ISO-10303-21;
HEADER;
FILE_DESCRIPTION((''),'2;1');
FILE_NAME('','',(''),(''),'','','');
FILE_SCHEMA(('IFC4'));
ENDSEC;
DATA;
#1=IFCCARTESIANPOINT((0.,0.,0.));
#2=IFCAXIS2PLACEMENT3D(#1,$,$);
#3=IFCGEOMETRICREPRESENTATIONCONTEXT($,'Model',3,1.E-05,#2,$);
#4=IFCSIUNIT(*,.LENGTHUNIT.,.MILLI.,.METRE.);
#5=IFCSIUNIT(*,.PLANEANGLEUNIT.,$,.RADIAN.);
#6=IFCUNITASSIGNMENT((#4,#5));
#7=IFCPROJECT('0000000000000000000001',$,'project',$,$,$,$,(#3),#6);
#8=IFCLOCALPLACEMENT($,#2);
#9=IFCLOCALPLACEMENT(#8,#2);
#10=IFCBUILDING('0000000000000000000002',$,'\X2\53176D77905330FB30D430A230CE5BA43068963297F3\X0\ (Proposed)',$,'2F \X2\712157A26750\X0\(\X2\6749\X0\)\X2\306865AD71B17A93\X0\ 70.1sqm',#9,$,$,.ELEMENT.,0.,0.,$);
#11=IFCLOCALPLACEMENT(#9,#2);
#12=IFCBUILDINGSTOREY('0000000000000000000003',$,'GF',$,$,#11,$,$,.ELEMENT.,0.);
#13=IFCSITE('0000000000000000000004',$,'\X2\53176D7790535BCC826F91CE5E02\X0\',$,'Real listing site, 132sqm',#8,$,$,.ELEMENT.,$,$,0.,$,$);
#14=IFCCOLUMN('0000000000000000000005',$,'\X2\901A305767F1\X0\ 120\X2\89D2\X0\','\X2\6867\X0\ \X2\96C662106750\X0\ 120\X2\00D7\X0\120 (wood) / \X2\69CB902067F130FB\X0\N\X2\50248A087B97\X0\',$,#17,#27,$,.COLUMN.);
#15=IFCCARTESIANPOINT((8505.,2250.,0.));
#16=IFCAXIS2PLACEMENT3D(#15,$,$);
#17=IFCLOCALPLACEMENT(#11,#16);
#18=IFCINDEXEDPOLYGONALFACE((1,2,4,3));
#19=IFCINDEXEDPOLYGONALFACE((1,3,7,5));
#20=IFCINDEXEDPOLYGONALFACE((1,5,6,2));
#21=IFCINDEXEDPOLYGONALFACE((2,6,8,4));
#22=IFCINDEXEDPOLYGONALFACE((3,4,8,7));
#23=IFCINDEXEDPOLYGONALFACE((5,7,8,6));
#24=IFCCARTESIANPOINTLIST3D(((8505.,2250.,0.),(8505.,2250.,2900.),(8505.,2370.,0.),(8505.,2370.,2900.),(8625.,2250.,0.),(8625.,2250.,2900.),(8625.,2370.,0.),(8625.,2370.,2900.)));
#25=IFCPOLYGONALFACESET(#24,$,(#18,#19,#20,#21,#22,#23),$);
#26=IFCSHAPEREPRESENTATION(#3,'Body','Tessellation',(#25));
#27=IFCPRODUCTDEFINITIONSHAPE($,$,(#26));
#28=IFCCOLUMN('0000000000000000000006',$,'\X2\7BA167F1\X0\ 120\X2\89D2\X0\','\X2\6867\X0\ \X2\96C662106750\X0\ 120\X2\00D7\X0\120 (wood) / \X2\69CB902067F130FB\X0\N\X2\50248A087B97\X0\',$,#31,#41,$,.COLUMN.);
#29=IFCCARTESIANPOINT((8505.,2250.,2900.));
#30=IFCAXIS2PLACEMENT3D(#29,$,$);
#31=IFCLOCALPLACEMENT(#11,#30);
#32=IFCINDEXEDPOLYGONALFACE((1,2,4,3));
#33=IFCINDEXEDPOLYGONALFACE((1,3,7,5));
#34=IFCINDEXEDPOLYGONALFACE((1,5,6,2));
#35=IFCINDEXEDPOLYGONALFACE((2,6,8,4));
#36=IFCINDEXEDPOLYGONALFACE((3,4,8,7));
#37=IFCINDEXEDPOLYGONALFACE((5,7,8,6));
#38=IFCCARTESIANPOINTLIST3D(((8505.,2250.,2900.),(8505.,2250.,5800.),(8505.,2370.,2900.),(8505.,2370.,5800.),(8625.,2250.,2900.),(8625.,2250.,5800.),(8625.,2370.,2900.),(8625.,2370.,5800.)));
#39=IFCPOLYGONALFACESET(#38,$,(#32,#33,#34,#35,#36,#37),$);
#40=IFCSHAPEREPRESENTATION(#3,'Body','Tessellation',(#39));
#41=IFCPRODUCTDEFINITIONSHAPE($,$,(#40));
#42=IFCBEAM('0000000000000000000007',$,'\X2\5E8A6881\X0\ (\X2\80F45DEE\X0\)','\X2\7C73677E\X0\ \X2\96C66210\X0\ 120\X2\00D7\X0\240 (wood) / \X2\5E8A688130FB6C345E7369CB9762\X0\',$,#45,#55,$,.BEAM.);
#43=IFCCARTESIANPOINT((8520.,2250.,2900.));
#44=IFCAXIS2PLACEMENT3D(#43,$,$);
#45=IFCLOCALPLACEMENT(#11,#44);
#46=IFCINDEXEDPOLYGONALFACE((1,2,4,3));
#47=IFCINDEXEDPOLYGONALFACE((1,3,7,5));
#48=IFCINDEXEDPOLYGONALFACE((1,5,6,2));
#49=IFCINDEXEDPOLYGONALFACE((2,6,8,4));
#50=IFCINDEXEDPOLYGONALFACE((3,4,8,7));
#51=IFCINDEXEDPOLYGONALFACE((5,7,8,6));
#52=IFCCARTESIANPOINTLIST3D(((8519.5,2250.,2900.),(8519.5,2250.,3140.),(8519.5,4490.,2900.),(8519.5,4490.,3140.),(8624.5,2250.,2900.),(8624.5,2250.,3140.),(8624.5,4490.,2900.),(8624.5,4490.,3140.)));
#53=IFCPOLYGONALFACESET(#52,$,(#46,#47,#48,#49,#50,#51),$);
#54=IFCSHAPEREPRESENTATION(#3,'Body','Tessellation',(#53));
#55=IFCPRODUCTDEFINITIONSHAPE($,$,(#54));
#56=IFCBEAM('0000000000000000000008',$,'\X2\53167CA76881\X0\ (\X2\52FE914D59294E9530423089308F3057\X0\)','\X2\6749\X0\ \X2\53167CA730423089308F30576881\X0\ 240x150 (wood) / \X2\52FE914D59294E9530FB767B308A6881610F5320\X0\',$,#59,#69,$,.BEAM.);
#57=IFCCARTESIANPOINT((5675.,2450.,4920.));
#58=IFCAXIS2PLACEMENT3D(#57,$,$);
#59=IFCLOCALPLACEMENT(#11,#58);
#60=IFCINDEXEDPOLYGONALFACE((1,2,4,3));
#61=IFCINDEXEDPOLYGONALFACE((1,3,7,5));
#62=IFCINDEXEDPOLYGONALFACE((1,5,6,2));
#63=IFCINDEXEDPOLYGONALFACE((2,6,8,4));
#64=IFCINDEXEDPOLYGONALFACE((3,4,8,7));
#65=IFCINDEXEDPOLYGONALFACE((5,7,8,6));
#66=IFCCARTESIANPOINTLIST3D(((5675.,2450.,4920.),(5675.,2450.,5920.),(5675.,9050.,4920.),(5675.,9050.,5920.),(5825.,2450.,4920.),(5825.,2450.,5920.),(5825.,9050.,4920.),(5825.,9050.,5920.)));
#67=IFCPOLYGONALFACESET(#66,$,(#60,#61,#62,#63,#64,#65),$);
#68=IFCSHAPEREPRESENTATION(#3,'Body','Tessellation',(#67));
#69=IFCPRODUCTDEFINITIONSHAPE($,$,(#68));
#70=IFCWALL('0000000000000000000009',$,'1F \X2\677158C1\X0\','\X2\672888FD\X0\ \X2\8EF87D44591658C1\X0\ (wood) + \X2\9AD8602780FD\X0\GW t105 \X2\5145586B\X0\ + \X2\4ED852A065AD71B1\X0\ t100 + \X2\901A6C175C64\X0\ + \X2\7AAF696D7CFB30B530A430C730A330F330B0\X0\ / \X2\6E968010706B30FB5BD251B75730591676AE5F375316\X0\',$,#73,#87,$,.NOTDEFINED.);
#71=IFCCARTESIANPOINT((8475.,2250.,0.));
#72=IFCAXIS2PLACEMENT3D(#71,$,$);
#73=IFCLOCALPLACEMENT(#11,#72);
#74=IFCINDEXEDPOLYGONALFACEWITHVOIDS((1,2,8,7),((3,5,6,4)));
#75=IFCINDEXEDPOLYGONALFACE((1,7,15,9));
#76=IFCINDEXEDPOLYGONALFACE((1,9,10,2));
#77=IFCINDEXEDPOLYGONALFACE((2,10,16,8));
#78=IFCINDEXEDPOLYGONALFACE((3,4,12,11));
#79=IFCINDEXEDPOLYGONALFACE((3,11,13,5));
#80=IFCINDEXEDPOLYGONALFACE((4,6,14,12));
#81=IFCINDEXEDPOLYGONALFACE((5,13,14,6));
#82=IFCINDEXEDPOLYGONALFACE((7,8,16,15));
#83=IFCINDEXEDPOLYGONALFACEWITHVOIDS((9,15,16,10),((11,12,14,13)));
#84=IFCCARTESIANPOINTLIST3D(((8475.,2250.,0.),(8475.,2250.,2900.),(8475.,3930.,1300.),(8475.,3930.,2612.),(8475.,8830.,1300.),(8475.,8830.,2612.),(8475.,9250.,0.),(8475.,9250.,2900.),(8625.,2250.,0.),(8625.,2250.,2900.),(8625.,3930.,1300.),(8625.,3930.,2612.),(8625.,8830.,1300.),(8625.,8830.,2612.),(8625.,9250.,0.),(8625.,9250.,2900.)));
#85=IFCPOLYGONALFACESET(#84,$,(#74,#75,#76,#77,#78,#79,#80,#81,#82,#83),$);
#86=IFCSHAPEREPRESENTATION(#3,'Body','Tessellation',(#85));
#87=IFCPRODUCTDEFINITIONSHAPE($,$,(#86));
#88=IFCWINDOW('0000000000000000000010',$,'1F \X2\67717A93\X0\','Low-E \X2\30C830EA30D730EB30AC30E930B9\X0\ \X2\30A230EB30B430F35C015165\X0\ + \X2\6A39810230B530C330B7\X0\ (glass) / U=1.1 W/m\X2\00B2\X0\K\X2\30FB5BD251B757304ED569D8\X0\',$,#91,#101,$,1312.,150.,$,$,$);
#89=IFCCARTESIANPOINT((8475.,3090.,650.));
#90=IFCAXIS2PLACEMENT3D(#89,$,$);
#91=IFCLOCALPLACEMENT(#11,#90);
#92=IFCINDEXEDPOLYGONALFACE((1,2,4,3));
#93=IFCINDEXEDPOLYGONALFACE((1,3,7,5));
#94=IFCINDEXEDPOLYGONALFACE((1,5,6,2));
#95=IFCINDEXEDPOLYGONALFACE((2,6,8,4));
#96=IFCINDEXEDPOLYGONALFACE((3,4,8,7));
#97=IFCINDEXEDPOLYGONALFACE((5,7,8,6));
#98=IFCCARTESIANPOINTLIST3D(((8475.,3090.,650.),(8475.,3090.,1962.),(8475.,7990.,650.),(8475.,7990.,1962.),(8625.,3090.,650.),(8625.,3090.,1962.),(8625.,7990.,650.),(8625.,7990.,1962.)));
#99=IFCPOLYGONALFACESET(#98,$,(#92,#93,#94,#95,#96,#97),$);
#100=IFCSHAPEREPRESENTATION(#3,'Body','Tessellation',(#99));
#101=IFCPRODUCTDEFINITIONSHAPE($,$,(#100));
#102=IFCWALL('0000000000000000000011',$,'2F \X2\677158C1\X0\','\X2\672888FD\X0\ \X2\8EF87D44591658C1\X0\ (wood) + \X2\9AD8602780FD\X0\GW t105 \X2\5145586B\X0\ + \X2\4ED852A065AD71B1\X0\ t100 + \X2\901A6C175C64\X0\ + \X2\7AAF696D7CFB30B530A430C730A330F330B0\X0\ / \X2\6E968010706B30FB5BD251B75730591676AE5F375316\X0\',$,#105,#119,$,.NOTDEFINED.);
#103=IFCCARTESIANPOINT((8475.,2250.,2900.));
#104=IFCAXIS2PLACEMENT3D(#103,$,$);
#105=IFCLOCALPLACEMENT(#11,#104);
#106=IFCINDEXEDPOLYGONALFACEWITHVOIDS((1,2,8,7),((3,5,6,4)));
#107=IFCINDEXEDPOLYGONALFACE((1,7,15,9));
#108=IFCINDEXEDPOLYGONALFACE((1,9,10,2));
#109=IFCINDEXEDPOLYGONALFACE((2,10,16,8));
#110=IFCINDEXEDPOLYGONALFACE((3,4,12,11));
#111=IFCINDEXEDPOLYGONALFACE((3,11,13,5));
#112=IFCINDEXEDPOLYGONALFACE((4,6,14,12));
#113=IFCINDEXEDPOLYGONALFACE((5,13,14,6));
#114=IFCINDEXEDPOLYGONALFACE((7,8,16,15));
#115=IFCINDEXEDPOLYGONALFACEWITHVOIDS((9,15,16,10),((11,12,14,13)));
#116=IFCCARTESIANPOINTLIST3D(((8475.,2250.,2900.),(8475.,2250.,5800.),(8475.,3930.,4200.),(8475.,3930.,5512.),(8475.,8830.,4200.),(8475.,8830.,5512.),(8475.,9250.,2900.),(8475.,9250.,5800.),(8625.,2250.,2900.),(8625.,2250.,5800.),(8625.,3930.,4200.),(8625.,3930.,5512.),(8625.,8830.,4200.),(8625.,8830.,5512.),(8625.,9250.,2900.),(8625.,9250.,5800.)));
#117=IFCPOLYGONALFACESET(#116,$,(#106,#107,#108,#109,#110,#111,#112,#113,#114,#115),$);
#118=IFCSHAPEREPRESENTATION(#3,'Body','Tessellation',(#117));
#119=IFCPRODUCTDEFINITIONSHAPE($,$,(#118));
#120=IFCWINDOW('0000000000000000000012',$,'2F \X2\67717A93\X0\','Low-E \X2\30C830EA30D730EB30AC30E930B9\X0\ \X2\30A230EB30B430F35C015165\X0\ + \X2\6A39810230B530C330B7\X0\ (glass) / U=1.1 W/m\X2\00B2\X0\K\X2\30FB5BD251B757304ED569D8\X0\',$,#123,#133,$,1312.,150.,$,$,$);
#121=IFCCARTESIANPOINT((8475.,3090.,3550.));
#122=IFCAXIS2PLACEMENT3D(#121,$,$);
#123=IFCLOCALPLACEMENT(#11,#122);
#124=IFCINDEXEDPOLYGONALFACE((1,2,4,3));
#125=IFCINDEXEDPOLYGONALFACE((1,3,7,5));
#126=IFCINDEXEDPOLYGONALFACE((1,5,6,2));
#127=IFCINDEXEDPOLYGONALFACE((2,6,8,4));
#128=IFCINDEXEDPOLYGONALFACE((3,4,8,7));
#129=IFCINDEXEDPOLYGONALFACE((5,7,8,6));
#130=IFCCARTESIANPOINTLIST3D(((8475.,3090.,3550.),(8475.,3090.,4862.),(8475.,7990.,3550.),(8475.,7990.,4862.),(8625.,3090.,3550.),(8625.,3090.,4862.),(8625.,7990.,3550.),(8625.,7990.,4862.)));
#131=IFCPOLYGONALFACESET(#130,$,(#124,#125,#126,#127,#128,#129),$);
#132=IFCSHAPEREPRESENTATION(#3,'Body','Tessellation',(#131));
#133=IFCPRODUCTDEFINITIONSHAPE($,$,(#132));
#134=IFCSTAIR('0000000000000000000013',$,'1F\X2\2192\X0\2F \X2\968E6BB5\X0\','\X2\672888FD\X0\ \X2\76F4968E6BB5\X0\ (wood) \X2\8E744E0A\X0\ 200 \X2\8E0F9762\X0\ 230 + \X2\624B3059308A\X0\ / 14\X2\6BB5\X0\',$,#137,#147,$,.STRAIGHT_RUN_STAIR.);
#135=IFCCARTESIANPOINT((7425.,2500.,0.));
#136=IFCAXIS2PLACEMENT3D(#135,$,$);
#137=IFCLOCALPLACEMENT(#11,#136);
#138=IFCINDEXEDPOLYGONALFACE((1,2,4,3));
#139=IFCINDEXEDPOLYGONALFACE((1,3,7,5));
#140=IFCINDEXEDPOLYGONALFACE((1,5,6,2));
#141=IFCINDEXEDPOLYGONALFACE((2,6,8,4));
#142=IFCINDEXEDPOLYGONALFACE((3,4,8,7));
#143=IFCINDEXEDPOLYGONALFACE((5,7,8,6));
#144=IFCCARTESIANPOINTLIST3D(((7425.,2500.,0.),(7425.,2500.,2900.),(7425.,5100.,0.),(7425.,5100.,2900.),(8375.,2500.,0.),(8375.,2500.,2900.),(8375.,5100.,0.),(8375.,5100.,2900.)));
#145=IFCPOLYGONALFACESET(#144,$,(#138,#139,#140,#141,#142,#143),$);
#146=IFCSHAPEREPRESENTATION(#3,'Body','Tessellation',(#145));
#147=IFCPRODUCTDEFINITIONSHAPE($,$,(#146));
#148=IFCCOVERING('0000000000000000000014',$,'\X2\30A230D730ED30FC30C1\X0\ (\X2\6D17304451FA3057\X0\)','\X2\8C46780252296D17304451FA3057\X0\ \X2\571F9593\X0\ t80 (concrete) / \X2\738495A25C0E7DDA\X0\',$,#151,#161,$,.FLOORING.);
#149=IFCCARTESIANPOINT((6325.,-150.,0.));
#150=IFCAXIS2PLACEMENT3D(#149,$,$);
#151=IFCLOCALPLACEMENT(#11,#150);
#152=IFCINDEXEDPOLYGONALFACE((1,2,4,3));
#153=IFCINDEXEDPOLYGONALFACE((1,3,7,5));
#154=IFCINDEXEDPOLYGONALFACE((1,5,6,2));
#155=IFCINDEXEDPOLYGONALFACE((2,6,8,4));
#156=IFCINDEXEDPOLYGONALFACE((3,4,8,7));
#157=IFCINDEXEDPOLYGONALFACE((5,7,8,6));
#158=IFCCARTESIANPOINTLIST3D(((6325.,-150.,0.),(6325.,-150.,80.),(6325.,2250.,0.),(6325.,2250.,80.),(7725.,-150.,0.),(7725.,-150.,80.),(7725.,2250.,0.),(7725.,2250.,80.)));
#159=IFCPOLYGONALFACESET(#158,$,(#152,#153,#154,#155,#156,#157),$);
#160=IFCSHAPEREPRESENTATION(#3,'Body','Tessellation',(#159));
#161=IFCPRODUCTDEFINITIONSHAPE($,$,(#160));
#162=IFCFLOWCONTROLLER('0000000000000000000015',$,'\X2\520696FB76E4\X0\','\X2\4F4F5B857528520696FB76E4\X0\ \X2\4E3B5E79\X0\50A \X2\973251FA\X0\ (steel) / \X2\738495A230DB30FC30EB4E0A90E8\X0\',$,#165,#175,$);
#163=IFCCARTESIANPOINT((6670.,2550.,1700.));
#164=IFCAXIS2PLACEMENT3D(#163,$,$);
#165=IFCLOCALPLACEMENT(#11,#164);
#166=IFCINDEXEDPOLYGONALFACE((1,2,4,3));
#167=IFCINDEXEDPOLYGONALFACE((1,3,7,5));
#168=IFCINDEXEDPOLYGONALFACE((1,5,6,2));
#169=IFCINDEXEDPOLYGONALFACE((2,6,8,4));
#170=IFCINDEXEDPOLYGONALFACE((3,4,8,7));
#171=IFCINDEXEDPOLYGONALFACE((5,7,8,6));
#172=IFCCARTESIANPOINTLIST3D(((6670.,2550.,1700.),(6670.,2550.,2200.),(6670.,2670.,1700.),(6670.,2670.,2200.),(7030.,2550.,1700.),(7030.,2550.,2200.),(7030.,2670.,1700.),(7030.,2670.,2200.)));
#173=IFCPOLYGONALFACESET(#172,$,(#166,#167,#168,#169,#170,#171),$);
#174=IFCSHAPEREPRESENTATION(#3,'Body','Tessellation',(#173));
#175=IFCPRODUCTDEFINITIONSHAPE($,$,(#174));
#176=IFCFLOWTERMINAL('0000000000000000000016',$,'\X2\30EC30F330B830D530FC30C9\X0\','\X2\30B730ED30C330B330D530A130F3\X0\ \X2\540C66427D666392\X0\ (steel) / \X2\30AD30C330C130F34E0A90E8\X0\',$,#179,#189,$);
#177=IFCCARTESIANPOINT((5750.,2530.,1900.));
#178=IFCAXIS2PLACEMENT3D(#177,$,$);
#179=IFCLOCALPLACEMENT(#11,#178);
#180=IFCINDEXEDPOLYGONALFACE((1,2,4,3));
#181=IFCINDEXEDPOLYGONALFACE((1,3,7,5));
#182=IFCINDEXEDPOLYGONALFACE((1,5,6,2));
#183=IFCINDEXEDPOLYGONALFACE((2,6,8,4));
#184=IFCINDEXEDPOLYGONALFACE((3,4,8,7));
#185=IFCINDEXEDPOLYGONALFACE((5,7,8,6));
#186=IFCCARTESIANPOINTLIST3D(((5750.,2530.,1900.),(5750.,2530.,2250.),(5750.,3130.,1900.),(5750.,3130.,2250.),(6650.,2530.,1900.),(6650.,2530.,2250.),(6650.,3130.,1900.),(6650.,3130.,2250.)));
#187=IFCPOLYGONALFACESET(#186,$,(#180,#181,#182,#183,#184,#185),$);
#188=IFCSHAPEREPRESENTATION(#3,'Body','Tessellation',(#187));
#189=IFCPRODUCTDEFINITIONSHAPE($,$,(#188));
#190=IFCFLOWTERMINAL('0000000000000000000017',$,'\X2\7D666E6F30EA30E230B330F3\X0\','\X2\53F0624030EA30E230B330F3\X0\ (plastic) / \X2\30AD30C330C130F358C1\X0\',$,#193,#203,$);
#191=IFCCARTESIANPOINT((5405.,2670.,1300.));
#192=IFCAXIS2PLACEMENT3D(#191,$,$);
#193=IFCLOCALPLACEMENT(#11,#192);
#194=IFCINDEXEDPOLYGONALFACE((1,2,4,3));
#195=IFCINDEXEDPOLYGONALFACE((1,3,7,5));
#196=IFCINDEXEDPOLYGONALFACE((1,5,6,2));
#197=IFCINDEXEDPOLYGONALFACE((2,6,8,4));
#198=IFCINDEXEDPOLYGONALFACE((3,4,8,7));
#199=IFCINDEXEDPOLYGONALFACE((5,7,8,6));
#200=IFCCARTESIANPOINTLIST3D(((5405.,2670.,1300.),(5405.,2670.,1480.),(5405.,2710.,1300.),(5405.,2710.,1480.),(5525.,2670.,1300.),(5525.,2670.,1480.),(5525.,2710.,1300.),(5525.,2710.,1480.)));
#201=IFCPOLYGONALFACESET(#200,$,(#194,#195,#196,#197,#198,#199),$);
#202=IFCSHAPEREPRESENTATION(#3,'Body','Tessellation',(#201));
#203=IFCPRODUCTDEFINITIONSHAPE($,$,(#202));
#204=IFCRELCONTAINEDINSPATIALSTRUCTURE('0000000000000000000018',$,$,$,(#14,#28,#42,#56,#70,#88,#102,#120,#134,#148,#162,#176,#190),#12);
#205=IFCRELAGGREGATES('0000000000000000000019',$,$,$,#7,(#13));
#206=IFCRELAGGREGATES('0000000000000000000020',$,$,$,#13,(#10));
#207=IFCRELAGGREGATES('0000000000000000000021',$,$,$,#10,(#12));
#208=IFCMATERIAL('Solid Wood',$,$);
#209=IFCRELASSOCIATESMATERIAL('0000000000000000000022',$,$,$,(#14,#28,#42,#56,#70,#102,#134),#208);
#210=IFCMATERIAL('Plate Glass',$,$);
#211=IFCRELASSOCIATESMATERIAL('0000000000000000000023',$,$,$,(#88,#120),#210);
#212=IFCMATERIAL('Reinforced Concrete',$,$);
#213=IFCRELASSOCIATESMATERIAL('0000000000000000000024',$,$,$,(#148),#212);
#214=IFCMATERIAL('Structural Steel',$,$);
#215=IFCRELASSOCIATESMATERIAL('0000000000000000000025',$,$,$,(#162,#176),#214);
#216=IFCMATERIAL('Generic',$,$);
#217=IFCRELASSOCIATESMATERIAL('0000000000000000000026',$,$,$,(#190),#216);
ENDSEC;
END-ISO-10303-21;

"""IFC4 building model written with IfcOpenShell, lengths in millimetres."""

from ifc_helpers import new_model, si_unit, frame, frame_2d, origin, place, context, project, spatial, rectangle, extrude, material, element, fill, save


model = new_model("IFC4")

# Units and contexts
model_context = context("Model", 3, precision=1e-05, world=origin())
ifc_project = project(units=[si_unit("LENGTHUNIT", "METRE", prefix="MILLI"), si_unit("PLANEANGLEUNIT", "RADIAN")], contexts=[model_context])

# Site, building, storey
site_placement = place(None, origin())
site = spatial("IfcSite", under=ifc_project, at=site_placement, Name="北海道富良野市", ObjectType="Real listing site, 132sqm", CompositionType="ELEMENT", RefElevation=0.0)
building_placement = place(site_placement, origin())
building = spatial("IfcBuilding", under=site, at=building_placement, Name="北海道・ピアノ室と防音 (Proposed)", ObjectType="2F 無垢材(杉)と断熱窓 70.1sqm", CompositionType="ELEMENT", ElevationOfRefHeight=0.0, ElevationOfTerrain=0.0)
storey_placement = place(building_placement, origin())
storey = spatial("IfcBuildingStorey", under=building, at=storey_placement, Name="GF", CompositionType="ELEMENT", Elevation=0.0)

# Columns
ifc_material_1 = material(Name="Solid Wood")
column_1_placement = place(storey_placement, frame((8505.0, 2250.0, 0.0)))
element("IfcColumn", 1, at=column_1_placement, inside=storey, material=ifc_material_1, Name="通し柱 120角", Description="桧 集成材 120×120 (wood) / 構造柱・N値計算", PredefinedType="COLUMN", context=model_context, shape_type="SweptSolid", body=[
    extrude(rectangle(XDim=120.0, YDim=120.0, at=frame_2d((60.0, 60.0))), frame((8505.0, 2250.0, 0.0)), (0.0, 0.0, 1.0), 2900.0),
])
column_2_placement = place(storey_placement, frame((8505.0, 2250.0, 2900.0)))
element("IfcColumn", 2, at=column_2_placement, inside=storey, material=ifc_material_1, Name="管柱 120角", Description="桧 集成材 120×120 (wood) / 構造柱・N値計算", PredefinedType="COLUMN", context=model_context, shape_type="SweptSolid", body=[
    extrude(rectangle(XDim=120.0, YDim=120.0, at=frame_2d((60.0, 60.0))), frame((8505.0, 2250.0, 2900.0)), (0.0, 0.0, 1.0), 2900.0),
])

# Beams
beam_1_placement = place(storey_placement, frame((8520.0, 2250.0, 2900.0)))
element("IfcBeam", 3, at=beam_1_placement, inside=storey, material=ifc_material_1, Name="床梁 (胴差)", Description="米松 集成 120×240 (wood) / 床梁・水平構面", PredefinedType="BEAM", context=model_context, shape_type="SweptSolid", body=[
    extrude(rectangle(XDim=105.0, YDim=2240.0, at=frame_2d((52.0, 1120.0))), frame((8520.0, 2250.0, 2900.0)), (0.0, 0.0, 1.0), 240.0),
])
beam_2_placement = place(storey_placement, frame((5675.0, 2450.0, 4920.0)))
element("IfcBeam", 4, at=beam_2_placement, inside=storey, material=ifc_material_1, Name="化粧梁 (勾配天井あらわし)", Description="杉 化粧あらわし梁 240x150 (wood) / 勾配天井・登り梁意匠", PredefinedType="BEAM", context=model_context, shape_type="SweptSolid", body=[
    extrude(rectangle(XDim=150.0, YDim=6600.0, at=frame_2d((75.0, 3300.0))), frame((5675.0, 2450.0, 4920.0)), (0.0, 0.0, 1.0), 1000.0),
])

# Wall, opening, window
wall_1_placement = place(storey_placement, frame((8475.0, 2250.0, 0.0)))
wall_1 = element("IfcWall", 5, at=wall_1_placement, inside=storey, material=ifc_material_1, Name="1F 東壁", Description="木製 軸組外壁 (wood) + 高性能GW t105 充填 + 付加断熱 t100 + 通気層 + 窯業系サイディング / 準耐火・寒冷地外皮強化", PredefinedType="NOTDEFINED", context=model_context, shape_type="SweptSolid", body=[
    extrude(rectangle(XDim=150.0, YDim=7000.0, at=frame_2d((75.0, 3500.0))), frame((8475.0, 2250.0, 0.0)), (0.0, 0.0, 1.0), 2900.0),
])
opening_1_placement = place(storey_placement, frame((8475.0, 3090.0, 650.0)))
opening_1 = element("IfcOpeningElement", 6, at=opening_1_placement, cuts=wall_1, PredefinedType="NOTDEFINED", context=model_context, shape_type="SweptSolid", body=[
    extrude(rectangle(XDim=150.0, YDim=4900.0, at=frame_2d((75.0, 2450.0))), frame((8475.0, 3090.0, 650.0)), (0.0, 0.0, 1.0), 1312.0),
])
ifc_material_2 = material(Name="Plate Glass")
window_1_placement = place(storey_placement, frame((8475.0, 3090.0, 650.0)))
window_1 = element("IfcWindow", 7, at=window_1_placement, inside=storey, material=ifc_material_2, Name="1F 東窓", Description="Low-E トリプルガラス アルゴン封入 + 樹脂サッシ (glass) / U=1.1 W/m²K・寒冷地仕様", OverallHeight=1312.0, OverallWidth=150.0, context=model_context, shape_type="SweptSolid", body=[
    extrude(rectangle(XDim=150.0, YDim=4900.0, at=frame_2d((75.0, 2450.0))), frame((8475.0, 3090.0, 650.0)), (0.0, 0.0, 1.0), 1312.0),
])
fill(opening_1, window_1)

# Wall, opening, window
wall_2_placement = place(storey_placement, frame((8475.0, 2250.0, 2900.0)))
wall_2 = element("IfcWall", 8, at=wall_2_placement, inside=storey, material=ifc_material_1, Name="2F 東壁", Description="木製 軸組外壁 (wood) + 高性能GW t105 充填 + 付加断熱 t100 + 通気層 + 窯業系サイディング / 準耐火・寒冷地外皮強化", PredefinedType="NOTDEFINED", context=model_context, shape_type="SweptSolid", body=[
    extrude(rectangle(XDim=150.0, YDim=7000.0, at=frame_2d((75.0, 3500.0))), frame((8475.0, 2250.0, 2900.0)), (0.0, 0.0, 1.0), 2900.0),
])
opening_2_placement = place(storey_placement, frame((8475.0, 3090.0, 3550.0)))
opening_2 = element("IfcOpeningElement", 9, at=opening_2_placement, cuts=wall_2, PredefinedType="NOTDEFINED", context=model_context, shape_type="SweptSolid", body=[
    extrude(rectangle(XDim=150.0, YDim=4900.0, at=frame_2d((75.0, 2450.0))), frame((8475.0, 3090.0, 3550.0)), (0.0, 0.0, 1.0), 1312.0),
])
window_2_placement = place(storey_placement, frame((8475.0, 3090.0, 3550.0)))
window_2 = element("IfcWindow", 10, at=window_2_placement, inside=storey, material=ifc_material_2, Name="2F 東窓", Description="Low-E トリプルガラス アルゴン封入 + 樹脂サッシ (glass) / U=1.1 W/m²K・寒冷地仕様", OverallHeight=1312.0, OverallWidth=150.0, context=model_context, shape_type="SweptSolid", body=[
    extrude(rectangle(XDim=150.0, YDim=4900.0, at=frame_2d((75.0, 2450.0))), frame((8475.0, 3090.0, 3550.0)), (0.0, 0.0, 1.0), 1312.0),
])
fill(opening_2, window_2)

# Stair
stair_placement = place(storey_placement, frame((7425.0, 2500.0, 0.0)))
element("IfcStair", 11, at=stair_placement, inside=storey, material=ifc_material_1, Name="1F→2F 階段", Description="木製 直階段 (wood) 蹴上 200 踏面 230 + 手すり / 14段", PredefinedType="STRAIGHT_RUN_STAIR", context=model_context, shape_type="SweptSolid", body=[
    extrude(rectangle(XDim=950.0, YDim=2600.0, at=frame_2d((475.0, 1300.0))), frame((7425.0, 2500.0, 0.0)), (0.0, 0.0, 1.0), 2900.0),
])

# Covering
ifc_material_3 = material(Name="Reinforced Concrete")
covering_placement = place(storey_placement, frame((6325.0, -150.0, 0.0)))
element("IfcCovering", 12, at=covering_placement, inside=storey, material=ifc_material_3, Name="アプローチ (洗い出し)", Description="豆砂利洗い出し 土間 t80 (concrete) / 玄関導線", PredefinedType="FLOORING", context=model_context, shape_type="SweptSolid", body=[
    extrude(rectangle(XDim=1400.0, YDim=2400.0, at=frame_2d((700.0, 1200.0))), frame((6325.0, -150.0, 0.0)), (0.0, 0.0, 1.0), 80.0),
])

# Flow controller
ifc_material_4 = material(Name="Structural Steel")
flow_controller_placement = place(storey_placement, frame((6670.0, 2550.0, 1700.0)))
element("IfcFlowController", 13, at=flow_controller_placement, inside=storey, material=ifc_material_4, Name="分電盤", Description="住宅用分電盤 主幹50A 露出 (steel) / 玄関ホール上部", context=model_context, shape_type="SweptSolid", body=[
    extrude(rectangle(XDim=360.0, YDim=120.0, at=frame_2d((180.0, 60.0))), frame((6670.0, 2550.0, 1700.0)), (0.0, 0.0, 1.0), 500.0),
])

# Flow terminals
flow_terminal_1_placement = place(storey_placement, frame((5750.0, 2530.0, 1900.0)))
element("IfcFlowTerminal", 14, at=flow_terminal_1_placement, inside=storey, material=ifc_material_4, Name="レンジフード", Description="シロッコファン 同時給排 (steel) / キッチン上部", context=model_context, shape_type="SweptSolid", body=[
    extrude(rectangle(XDim=900.0, YDim=600.0, at=frame_2d((450.0, 300.0))), frame((5750.0, 2530.0, 1900.0)), (0.0, 0.0, 1.0), 350.0),
])
ifc_material_5 = material(Name="Generic")
flow_terminal_2_placement = place(storey_placement, frame((5405.0, 2670.0, 1300.0)))
element("IfcFlowTerminal", 15, at=flow_terminal_2_placement, inside=storey, material=ifc_material_5, Name="給湯リモコン", Description="台所リモコン (plastic) / キッチン壁", context=model_context, shape_type="SweptSolid", body=[
    extrude(rectangle(XDim=120.0, YDim=40.0, at=frame_2d((60.0, 20.0))), frame((5405.0, 2670.0, 1300.0)), (0.0, 0.0, 1.0), 180.0),
])

save(model, "model.ifc")
